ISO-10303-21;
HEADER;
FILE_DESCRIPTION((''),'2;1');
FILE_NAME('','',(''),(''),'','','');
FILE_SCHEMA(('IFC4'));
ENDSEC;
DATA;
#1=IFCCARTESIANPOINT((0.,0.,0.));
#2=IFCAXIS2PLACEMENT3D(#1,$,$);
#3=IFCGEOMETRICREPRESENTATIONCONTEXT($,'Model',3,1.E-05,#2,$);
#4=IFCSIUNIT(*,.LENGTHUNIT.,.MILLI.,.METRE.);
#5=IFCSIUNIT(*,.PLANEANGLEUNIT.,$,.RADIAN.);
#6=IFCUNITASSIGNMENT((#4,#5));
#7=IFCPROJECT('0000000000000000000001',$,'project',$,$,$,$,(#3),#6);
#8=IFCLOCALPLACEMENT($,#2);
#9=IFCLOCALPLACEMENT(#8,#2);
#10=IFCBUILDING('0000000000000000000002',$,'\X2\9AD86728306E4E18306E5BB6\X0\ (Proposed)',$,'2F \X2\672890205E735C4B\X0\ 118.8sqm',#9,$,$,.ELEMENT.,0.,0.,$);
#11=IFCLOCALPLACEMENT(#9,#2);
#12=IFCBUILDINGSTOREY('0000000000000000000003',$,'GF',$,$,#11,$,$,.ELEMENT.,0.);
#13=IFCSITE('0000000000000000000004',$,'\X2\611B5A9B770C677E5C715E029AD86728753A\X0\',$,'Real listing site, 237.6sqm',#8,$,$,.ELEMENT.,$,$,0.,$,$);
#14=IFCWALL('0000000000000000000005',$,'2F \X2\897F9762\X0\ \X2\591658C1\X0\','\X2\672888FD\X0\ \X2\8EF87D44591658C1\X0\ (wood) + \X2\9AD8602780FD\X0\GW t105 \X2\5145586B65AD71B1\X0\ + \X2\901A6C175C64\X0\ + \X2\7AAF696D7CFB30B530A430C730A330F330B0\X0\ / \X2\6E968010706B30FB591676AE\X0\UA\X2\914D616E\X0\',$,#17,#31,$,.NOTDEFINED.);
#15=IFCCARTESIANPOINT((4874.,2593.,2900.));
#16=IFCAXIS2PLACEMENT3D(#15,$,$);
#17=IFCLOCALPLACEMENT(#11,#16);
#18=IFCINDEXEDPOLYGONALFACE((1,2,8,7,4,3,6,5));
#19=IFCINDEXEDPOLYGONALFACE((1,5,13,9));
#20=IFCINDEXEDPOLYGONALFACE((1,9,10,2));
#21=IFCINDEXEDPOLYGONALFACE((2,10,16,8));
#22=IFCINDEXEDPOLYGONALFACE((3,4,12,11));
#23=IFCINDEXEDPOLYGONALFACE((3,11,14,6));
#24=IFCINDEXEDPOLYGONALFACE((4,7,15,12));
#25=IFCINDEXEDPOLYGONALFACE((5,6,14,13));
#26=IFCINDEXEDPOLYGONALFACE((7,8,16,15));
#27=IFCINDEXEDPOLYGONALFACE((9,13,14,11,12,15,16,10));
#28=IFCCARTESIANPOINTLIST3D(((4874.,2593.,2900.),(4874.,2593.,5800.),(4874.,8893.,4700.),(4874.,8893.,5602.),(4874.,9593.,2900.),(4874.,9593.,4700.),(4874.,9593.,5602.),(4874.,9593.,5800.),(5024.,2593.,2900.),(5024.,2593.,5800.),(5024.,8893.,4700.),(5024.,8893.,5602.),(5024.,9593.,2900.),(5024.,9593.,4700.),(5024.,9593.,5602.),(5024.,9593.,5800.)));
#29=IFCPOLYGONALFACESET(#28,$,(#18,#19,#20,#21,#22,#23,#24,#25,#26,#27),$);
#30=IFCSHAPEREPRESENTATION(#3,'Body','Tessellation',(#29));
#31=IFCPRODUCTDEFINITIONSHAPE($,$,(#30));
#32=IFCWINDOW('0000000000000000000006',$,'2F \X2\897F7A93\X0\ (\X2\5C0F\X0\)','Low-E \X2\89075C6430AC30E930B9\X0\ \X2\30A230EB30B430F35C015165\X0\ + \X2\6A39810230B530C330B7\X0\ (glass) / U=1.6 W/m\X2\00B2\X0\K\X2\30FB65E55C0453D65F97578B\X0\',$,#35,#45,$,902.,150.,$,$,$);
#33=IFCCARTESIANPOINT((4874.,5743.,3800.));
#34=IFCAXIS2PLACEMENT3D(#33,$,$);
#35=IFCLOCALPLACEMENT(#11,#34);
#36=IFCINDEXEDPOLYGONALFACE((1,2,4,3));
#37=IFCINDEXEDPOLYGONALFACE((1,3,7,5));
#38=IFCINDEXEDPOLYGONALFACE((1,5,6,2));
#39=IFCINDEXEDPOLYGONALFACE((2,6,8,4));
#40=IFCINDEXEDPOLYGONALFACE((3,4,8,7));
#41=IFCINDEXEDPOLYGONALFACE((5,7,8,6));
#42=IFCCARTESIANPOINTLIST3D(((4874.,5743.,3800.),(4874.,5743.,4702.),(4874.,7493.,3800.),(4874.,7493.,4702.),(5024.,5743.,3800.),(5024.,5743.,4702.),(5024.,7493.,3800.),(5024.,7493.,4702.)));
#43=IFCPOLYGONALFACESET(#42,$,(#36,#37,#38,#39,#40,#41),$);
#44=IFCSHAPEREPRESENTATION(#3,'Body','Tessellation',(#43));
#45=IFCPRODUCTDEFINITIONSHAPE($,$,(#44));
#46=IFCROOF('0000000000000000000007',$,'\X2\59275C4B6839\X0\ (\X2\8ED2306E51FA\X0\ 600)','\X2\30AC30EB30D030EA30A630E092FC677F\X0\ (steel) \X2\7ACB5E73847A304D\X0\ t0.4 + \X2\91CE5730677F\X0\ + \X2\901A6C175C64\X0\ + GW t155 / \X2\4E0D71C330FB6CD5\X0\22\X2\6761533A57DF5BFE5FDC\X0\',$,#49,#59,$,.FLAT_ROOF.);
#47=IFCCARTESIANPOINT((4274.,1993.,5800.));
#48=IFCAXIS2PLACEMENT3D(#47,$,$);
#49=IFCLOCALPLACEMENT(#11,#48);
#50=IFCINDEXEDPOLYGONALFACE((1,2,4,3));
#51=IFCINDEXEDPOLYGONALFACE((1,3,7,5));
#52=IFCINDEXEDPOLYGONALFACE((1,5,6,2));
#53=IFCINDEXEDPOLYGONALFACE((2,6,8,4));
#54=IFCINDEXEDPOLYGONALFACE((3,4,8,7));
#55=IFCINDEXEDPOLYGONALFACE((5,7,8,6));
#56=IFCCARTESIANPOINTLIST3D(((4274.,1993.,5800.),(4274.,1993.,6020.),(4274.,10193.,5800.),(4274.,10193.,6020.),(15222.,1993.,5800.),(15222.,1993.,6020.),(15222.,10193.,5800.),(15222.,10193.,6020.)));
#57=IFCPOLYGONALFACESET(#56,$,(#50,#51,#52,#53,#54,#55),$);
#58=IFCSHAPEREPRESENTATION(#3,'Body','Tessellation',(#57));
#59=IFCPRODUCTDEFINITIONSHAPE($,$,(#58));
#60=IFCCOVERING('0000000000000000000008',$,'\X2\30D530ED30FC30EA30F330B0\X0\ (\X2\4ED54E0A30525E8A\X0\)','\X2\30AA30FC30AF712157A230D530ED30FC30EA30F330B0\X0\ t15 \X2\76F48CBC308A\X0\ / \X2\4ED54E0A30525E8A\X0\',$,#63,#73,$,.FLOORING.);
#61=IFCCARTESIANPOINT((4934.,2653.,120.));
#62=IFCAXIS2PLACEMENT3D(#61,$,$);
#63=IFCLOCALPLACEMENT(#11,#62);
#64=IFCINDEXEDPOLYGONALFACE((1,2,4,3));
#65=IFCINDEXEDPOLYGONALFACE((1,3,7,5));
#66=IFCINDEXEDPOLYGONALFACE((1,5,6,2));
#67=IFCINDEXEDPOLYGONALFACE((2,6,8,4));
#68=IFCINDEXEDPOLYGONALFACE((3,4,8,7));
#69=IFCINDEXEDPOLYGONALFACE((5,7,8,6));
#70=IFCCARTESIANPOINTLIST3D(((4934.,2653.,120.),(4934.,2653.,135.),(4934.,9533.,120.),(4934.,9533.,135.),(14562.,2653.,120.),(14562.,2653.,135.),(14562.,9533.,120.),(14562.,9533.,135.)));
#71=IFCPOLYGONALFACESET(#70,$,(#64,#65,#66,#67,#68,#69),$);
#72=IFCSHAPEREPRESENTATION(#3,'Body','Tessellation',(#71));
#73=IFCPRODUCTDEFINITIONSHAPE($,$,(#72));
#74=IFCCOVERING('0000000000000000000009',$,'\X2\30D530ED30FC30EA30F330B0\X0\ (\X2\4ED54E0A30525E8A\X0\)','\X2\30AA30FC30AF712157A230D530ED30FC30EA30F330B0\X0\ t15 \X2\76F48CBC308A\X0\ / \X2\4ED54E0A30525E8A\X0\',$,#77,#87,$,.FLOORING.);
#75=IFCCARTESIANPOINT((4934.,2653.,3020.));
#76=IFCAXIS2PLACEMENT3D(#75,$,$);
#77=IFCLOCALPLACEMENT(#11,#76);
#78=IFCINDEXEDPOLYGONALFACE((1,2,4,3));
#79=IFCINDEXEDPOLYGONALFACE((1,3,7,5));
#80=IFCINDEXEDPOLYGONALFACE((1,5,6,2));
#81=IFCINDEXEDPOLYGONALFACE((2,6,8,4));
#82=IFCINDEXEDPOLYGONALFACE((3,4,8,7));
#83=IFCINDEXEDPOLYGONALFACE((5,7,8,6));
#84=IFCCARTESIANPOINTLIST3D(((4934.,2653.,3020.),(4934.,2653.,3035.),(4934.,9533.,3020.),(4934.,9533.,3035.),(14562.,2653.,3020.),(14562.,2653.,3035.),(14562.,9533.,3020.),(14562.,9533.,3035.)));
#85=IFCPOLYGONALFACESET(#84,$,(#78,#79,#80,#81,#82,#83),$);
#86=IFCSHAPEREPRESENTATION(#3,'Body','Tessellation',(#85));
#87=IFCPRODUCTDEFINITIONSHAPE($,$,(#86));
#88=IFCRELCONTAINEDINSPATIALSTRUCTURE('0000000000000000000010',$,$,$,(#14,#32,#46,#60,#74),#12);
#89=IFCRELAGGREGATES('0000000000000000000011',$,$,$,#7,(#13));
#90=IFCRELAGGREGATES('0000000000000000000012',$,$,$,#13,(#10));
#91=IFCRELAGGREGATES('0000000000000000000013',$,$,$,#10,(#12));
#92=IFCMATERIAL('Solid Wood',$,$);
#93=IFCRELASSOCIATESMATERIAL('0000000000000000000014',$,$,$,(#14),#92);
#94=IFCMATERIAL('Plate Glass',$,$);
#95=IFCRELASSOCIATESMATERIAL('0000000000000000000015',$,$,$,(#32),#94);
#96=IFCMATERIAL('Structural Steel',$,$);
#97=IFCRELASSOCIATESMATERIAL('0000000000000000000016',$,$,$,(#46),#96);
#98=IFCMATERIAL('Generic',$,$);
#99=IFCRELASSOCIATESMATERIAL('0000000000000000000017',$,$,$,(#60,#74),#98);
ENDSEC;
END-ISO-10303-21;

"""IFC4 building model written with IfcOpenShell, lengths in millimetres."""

from ifc_helpers import new_model, si_unit, frame, frame_2d, origin, place, context, project, spatial, rectangle, extrude, material, element, fill, save


model = new_model("IFC4")

# Units and contexts
model_context = context("Model", 3, precision=1e-05, world=origin())
ifc_project = project(units=[si_unit("LENGTHUNIT", "METRE", prefix="MILLI"), si_unit("PLANEANGLEUNIT", "RADIAN")], contexts=[model_context])

# Site, building, storey
site_placement = place(None, origin())
site = spatial("IfcSite", under=ifc_project, at=site_placement, Name="愛媛県松山市高木町", ObjectType="Real listing site, 237.6sqm", CompositionType="ELEMENT", RefElevation=0.0)
building_placement = place(site_placement, origin())
building = spatial("IfcBuilding", under=site, at=building_placement, Name="高木の丘の家 (Proposed)", ObjectType="2F 木造平屋 118.8sqm", CompositionType="ELEMENT", ElevationOfRefHeight=0.0, ElevationOfTerrain=0.0)
storey_placement = place(building_placement, origin())
storey = spatial("IfcBuildingStorey", under=building, at=storey_placement, Name="GF", CompositionType="ELEMENT", Elevation=0.0)

# Shared definitions
ifc_material_1 = material(Name="Solid Wood")

# Shared definitions
ifc_material_2 = material(Name="Plate Glass")

# Wall, opening, window
wall_1_placement = place(storey_placement, frame((4874.0, 2593.0, 2900.0)))
wall_1 = element("IfcWall", 1, at=wall_1_placement, inside=storey, material=ifc_material_1, Name="2F 西面 外壁", Description="木製 軸組外壁 (wood) + 高性能GW t105 充填断熱 + 通気層 + 窯業系サイディング / 準耐火・外皮UA配慮", PredefinedType="NOTDEFINED", context=model_context, shape_type="SweptSolid", body=[
    extrude(rectangle(XDim=150.0, YDim=7000.0, at=frame_2d((75.0, 3500.0))), frame((4874.0, 2593.0, 2900.0)), (0.0, 0.0, 1.0), 2900.0),
])
opening_1_placement = place(storey_placement, frame((4874.0, 5743.0, 3800.0)))
opening_1 = element("IfcOpeningElement", 2, at=opening_1_placement, cuts=wall_1, PredefinedType="NOTDEFINED", context=model_context, shape_type="SweptSolid", body=[
    extrude(rectangle(XDim=150.0, YDim=1750.0, at=frame_2d((75.0, 875.0))), frame((4874.0, 5743.0, 3800.0)), (0.0, 0.0, 1.0), 902.0),
])
window_1_placement = place(storey_placement, frame((4874.0, 5743.0, 3800.0)))
window_1 = element("IfcWindow", 3, at=window_1_placement, inside=storey, material=ifc_material_2, Name="2F 西窓 (小)", Description="Low-E 複層ガラス アルゴン封入 + 樹脂サッシ (glass) / U=1.6 W/m²K・日射取得型", OverallHeight=902.0, OverallWidth=150.0, context=model_context, shape_type="SweptSolid", body=[
    extrude(rectangle(XDim=150.0, YDim=1750.0, at=frame_2d((75.0, 875.0))), frame((4874.0, 5743.0, 3800.0)), (0.0, 0.0, 1.0), 902.0),
])
fill(opening_1, window_1)

# Roof
ifc_material_3 = material(Name="Structural Steel")
roof_placement = place(storey_placement, frame((4274.0, 1993.0, 5800.0)))
element("IfcRoof", 4, at=roof_placement, inside=storey, material=ifc_material_3, Name="大屋根 (軒の出 600)", Description="ガルバリウム鋼板 (steel) 立平葺き t0.4 + 野地板 + 通気層 + GW t155 / 不燃・法22条区域対応", PredefinedType="FLAT_ROOF", context=model_context, shape_type="SweptSolid", body=[
    extrude(rectangle(XDim=10948.0, YDim=8200.0, at=frame_2d((5474.0, 4100.0))), frame((4274.0, 1993.0, 5800.0)), (0.0, 0.0, 1.0), 220.0),
])

# Coverings
ifc_material_4 = material(Name="Generic")
covering_1_placement = place(storey_placement, frame((4934.0, 2653.0, 120.0)))
element("IfcCovering", 5, at=covering_1_placement, inside=storey, material=ifc_material_4, Name="フローリング (仕上げ床)", Description="オーク無垢フローリング t15 直貼り / 仕上げ床", PredefinedType="FLOORING", context=model_context, shape_type="SweptSolid", body=[
    extrude(rectangle(XDim=9628.0, YDim=6880.0, at=frame_2d((4814.0, 3440.0))), frame((4934.0, 2653.0, 120.0)), (0.0, 0.0, 1.0), 15.0),
])
covering_2_placement = place(storey_placement, frame((4934.0, 2653.0, 3020.0)))
element("IfcCovering", 6, at=covering_2_placement, inside=storey, material=ifc_material_4, Name="フローリング (仕上げ床)", Description="オーク無垢フローリング t15 直貼り / 仕上げ床", PredefinedType="FLOORING", context=model_context, shape_type="SweptSolid", body=[
    extrude(rectangle(XDim=9628.0, YDim=6880.0, at=frame_2d((4814.0, 3440.0))), frame((4934.0, 2653.0, 3020.0)), (0.0, 0.0, 1.0), 15.0),
])

save(model, "model.ifc")
